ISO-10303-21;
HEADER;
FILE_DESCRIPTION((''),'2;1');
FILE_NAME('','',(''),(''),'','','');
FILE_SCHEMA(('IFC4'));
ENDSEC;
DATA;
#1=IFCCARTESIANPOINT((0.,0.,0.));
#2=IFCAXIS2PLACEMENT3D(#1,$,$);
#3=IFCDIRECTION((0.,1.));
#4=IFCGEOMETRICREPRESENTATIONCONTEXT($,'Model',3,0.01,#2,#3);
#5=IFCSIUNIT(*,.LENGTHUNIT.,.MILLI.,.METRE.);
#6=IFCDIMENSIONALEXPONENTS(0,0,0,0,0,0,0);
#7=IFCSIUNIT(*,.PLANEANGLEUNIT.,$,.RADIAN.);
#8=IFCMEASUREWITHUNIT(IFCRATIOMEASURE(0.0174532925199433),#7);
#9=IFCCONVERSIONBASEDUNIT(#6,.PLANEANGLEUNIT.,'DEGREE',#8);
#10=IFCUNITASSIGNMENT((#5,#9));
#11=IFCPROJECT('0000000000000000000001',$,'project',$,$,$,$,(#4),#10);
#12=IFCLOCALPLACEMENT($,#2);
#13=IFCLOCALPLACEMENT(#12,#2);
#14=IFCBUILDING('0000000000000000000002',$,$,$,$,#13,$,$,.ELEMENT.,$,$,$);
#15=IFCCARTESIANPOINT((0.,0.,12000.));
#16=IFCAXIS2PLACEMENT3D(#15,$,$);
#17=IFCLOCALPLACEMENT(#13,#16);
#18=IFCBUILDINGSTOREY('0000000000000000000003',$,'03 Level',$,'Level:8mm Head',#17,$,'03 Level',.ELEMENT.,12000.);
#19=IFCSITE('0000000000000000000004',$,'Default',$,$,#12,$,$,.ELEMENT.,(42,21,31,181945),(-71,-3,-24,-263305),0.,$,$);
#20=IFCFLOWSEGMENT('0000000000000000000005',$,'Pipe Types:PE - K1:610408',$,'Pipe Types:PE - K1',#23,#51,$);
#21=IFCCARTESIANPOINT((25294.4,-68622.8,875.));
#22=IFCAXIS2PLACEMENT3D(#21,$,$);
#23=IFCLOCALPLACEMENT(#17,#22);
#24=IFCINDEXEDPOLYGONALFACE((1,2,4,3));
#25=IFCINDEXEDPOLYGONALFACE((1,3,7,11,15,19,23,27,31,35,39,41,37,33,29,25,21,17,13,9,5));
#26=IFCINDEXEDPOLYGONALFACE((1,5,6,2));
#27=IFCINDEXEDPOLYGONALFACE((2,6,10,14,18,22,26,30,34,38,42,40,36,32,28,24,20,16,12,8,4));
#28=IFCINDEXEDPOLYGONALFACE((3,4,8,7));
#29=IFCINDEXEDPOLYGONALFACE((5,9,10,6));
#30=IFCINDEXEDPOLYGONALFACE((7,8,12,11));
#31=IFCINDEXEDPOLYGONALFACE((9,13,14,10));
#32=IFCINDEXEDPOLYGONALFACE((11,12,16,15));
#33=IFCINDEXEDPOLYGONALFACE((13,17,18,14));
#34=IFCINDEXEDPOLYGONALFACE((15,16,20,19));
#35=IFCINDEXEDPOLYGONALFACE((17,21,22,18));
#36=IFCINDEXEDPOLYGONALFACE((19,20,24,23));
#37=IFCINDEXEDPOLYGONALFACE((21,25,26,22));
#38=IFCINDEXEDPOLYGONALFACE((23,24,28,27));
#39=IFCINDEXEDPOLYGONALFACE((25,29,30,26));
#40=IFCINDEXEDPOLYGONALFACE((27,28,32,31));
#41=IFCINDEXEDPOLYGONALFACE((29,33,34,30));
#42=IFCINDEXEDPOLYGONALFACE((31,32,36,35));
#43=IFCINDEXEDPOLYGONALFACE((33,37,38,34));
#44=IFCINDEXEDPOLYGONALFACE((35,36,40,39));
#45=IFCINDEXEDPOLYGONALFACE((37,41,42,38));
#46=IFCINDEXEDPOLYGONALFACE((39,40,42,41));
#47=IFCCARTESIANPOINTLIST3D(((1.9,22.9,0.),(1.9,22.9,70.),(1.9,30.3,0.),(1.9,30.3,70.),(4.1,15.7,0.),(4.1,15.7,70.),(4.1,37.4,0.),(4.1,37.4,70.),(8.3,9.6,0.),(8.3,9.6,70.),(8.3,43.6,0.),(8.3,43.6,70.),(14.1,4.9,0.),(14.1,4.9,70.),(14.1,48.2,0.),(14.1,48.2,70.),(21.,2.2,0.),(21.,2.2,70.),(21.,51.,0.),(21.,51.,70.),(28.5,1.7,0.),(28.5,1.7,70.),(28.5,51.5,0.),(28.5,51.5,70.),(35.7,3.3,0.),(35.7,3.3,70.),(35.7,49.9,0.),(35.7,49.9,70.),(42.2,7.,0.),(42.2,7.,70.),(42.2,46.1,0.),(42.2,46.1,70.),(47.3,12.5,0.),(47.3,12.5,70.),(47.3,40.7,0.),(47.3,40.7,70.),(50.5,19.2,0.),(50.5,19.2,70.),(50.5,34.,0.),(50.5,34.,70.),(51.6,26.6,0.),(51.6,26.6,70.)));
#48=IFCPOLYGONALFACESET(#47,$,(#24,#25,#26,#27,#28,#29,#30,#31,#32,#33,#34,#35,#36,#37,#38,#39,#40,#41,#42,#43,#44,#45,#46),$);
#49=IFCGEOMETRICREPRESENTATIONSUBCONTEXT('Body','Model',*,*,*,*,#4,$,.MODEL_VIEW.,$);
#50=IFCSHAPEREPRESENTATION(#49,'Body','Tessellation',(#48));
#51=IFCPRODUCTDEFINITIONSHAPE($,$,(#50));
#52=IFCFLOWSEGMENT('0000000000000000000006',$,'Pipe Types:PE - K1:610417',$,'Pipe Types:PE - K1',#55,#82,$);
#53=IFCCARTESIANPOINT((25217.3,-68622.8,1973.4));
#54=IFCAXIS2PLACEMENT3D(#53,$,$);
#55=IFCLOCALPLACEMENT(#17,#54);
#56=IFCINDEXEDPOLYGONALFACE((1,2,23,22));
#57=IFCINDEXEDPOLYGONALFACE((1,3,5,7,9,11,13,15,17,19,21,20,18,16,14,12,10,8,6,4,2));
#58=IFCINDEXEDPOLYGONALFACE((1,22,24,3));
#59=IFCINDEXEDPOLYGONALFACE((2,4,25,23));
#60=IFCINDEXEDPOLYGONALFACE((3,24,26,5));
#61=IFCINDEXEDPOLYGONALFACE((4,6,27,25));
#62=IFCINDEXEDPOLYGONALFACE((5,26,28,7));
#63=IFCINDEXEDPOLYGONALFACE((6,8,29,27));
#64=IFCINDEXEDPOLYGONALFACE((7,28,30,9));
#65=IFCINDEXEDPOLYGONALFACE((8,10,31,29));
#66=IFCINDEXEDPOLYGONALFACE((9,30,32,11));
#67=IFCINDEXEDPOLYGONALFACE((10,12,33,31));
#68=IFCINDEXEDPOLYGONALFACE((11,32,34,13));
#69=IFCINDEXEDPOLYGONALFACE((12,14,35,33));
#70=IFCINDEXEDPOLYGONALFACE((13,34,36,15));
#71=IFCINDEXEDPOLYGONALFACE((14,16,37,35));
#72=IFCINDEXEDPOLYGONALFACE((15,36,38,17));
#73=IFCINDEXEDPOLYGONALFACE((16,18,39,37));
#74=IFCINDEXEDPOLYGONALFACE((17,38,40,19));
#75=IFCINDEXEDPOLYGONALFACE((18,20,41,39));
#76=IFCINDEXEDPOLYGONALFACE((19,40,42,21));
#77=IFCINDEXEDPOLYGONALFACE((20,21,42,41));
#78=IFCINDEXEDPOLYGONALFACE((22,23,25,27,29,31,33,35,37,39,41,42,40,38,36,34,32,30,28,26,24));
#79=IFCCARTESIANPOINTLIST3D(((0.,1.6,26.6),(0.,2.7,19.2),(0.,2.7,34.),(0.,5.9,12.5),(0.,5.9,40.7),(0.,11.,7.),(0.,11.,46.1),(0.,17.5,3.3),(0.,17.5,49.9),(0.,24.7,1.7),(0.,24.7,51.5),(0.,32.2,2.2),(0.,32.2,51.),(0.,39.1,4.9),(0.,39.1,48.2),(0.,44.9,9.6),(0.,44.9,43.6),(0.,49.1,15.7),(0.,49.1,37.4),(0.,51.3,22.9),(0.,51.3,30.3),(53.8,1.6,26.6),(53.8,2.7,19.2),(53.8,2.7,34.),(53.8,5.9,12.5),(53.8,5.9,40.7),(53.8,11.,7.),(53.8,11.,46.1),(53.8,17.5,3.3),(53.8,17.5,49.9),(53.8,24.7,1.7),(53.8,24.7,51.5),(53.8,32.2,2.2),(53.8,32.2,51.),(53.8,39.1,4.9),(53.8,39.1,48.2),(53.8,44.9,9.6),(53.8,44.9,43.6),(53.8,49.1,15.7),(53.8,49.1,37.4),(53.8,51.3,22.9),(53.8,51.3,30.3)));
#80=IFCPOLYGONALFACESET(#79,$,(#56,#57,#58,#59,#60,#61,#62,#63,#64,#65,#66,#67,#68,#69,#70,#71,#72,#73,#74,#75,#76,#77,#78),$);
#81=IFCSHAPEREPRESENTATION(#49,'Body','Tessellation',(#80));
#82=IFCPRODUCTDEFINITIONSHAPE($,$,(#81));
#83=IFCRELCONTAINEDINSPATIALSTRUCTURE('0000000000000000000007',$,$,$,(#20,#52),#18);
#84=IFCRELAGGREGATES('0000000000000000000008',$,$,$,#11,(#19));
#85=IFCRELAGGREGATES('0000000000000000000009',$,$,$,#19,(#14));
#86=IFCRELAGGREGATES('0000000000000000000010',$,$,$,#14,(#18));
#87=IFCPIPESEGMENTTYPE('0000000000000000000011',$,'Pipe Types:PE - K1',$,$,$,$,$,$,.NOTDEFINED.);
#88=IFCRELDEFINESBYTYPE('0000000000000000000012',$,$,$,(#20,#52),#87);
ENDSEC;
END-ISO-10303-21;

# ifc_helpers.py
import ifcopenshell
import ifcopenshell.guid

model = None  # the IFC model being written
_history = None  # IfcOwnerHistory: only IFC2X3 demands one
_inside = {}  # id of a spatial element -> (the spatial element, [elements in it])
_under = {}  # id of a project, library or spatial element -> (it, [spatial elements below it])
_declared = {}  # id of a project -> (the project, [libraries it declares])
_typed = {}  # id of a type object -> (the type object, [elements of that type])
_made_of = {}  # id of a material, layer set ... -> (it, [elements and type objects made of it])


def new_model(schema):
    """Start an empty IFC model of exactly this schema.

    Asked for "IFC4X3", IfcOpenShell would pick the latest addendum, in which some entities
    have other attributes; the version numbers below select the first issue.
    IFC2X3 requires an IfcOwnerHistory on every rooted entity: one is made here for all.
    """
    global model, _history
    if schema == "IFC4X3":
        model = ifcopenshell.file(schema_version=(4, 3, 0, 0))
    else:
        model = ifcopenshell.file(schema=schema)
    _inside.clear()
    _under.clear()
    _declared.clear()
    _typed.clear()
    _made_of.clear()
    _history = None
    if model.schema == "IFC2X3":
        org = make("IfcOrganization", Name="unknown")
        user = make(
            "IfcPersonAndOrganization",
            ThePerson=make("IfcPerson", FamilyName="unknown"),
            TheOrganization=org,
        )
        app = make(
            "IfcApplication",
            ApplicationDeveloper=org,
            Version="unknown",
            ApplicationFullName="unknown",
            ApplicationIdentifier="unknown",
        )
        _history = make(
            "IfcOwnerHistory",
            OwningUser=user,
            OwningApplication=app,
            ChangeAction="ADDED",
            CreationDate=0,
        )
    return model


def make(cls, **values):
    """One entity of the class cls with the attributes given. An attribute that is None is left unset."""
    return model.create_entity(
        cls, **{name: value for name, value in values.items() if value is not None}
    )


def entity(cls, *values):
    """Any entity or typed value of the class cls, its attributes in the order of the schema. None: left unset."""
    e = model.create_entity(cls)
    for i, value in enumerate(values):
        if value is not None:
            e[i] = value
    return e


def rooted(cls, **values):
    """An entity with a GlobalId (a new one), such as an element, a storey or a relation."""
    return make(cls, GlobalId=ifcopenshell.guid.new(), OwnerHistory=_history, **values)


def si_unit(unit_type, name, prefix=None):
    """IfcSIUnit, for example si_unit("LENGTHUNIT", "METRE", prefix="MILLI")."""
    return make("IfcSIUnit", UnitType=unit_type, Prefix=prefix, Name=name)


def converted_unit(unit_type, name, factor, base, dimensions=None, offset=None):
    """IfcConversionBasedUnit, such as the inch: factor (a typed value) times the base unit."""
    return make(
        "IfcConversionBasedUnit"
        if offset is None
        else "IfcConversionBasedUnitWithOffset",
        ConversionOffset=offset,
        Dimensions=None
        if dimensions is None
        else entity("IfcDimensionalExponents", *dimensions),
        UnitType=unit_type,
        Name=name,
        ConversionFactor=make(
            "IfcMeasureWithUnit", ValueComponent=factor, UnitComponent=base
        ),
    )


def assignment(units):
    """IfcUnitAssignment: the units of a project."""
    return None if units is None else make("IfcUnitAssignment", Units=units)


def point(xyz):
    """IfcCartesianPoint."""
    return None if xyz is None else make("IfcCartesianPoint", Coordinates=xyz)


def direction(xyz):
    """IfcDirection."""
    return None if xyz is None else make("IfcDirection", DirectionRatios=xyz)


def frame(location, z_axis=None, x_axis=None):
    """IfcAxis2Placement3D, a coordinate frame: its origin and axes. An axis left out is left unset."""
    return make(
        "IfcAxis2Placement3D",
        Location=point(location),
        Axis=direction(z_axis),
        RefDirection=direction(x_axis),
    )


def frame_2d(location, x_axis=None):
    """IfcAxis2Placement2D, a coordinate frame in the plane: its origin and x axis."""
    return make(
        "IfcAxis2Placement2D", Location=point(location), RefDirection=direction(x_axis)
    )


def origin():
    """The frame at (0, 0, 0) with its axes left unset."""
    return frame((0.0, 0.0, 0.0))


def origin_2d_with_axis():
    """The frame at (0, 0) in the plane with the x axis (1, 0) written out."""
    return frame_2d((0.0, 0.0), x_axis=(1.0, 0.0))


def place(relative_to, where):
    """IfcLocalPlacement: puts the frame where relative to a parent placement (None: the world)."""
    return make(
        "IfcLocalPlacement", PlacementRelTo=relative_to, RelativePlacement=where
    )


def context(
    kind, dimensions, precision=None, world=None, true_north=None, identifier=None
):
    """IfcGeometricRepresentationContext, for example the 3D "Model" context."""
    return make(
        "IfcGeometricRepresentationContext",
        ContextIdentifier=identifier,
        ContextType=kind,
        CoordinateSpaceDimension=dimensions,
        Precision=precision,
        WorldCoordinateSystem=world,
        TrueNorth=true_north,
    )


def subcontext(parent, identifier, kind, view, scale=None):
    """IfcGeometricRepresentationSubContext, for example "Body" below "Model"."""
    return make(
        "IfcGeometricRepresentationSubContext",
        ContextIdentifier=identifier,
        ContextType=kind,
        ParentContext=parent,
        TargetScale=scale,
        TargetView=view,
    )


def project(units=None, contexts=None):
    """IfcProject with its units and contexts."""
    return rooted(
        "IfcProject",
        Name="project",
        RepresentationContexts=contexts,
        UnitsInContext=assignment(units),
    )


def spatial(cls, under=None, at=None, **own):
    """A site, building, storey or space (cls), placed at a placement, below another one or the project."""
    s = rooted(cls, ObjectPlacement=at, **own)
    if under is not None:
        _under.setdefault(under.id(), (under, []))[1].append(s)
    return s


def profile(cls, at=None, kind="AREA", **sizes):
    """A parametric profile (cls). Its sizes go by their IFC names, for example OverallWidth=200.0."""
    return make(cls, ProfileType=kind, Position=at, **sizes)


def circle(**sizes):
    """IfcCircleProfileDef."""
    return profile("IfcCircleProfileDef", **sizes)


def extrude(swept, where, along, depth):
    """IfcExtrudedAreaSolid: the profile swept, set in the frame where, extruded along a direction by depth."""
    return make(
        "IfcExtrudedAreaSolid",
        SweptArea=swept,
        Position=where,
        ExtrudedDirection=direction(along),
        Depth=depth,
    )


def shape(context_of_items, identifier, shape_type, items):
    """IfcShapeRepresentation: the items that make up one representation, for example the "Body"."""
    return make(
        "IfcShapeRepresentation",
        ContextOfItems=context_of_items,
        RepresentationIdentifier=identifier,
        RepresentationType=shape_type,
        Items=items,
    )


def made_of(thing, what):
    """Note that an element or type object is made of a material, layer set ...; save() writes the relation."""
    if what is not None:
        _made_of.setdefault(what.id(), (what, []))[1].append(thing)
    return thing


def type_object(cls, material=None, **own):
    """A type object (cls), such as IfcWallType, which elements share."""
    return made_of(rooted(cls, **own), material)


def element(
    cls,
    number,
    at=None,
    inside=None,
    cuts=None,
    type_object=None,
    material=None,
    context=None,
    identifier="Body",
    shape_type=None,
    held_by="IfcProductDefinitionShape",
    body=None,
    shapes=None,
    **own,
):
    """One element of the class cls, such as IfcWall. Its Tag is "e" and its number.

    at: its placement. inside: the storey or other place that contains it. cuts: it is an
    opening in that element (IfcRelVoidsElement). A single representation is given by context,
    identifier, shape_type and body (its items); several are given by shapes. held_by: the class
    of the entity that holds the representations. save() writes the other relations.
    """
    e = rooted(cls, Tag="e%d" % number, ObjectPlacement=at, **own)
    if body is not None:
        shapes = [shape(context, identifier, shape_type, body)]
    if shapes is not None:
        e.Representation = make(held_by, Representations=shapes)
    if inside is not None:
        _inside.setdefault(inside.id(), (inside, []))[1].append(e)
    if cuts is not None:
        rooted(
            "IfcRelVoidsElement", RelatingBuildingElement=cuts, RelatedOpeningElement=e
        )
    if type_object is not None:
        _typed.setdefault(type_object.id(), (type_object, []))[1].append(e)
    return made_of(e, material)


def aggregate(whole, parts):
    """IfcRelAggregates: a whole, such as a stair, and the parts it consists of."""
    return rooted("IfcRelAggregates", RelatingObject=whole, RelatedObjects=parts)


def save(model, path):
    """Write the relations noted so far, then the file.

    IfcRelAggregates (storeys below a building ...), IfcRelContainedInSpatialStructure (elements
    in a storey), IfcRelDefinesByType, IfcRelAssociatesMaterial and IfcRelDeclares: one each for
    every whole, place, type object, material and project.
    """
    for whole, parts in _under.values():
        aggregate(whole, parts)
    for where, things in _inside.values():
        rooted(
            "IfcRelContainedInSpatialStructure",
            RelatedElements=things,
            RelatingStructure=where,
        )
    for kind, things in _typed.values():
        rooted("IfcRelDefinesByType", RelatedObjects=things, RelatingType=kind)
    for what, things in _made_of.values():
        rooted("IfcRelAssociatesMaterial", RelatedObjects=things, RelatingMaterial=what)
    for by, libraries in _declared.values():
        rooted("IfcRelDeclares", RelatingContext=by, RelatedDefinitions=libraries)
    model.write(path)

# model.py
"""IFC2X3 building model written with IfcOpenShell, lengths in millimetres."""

from ifc_helpers import new_model, entity, si_unit, converted_unit, direction, frame, frame_2d, origin, origin_2d_with_axis, place, context, subcontext, project, spatial, circle, extrude, type_object, element, save


model = new_model("IFC2X3")

# Units and contexts
model_context = context("Model", 3, precision=0.01, world=origin(), true_north=direction((0.0, 1.0)))
body_context = subcontext(model_context, "Body", "Model", "MODEL_VIEW")
ifc_project = project(units=[si_unit("LENGTHUNIT", "METRE", prefix="MILLI"), converted_unit("PLANEANGLEUNIT", "DEGREE", entity("IfcRatioMeasure", 0.0174532925199433), si_unit("PLANEANGLEUNIT", "RADIAN"), dimensions=[0, 0, 0, 0, 0, 0, 0])], contexts=[model_context])

# Site, building, storey
site_placement = place(None, origin())
site = spatial("IfcSite", under=ifc_project, at=site_placement, Name="Default", CompositionType="ELEMENT", RefLatitude=(42, 21, 31, 181945), RefLongitude=(-71, -3, -24, -263305), RefElevation=0.0)
building_placement = place(site_placement, origin())
building = spatial("IfcBuilding", under=site, at=building_placement, CompositionType="ELEMENT")
storey_placement = place(building_placement, frame((0.0, 0.0, 12000.0)))
storey = spatial("IfcBuildingStorey", under=building, at=storey_placement, Name="03 Level", ObjectType="Level:8mm Head", LongName="03 Level", CompositionType="ELEMENT", Elevation=12000.0)

# Flow segments
pipe_segment_type_1 = type_object("IfcPipeSegmentType", Name="Pipe Types:PE - K1", PredefinedType="NOTDEFINED")
flow_segment_1_placement = place(storey_placement, frame((25294.4, -68622.8, 875.0)))
element("IfcFlowSegment", 1, at=flow_segment_1_placement, inside=storey, type_object=pipe_segment_type_1, Name="Pipe Types:PE - K1:610408", ObjectType="Pipe Types:PE - K1", context=body_context, shape_type="SweptSolid", body=[
    extrude(circle(Radius=25.0, at=origin_2d_with_axis()), frame((26.6, 26.6, 0.0)), (0.0, 0.0, 1.0), 70.0),
])
flow_segment_2_placement = place(storey_placement, frame((25217.3, -68622.8, 1973.4)))
element("IfcFlowSegment", 2, at=flow_segment_2_placement, inside=storey, type_object=pipe_segment_type_1, Name="Pipe Types:PE - K1:610417", ObjectType="Pipe Types:PE - K1", context=body_context, shape_type="SweptSolid", body=[
    extrude(circle(Radius=25.0, at=frame_2d((0.0, 0.0), x_axis=(1.0, 0.0))), frame((0.0, 26.6, 26.6), z_axis=(1.0, 0.0, 0.0), x_axis=(0.0, -1.0, 0.0)), (0.0, 0.0, 1.0), 53.8),
])

save(model, "model.ifc")
